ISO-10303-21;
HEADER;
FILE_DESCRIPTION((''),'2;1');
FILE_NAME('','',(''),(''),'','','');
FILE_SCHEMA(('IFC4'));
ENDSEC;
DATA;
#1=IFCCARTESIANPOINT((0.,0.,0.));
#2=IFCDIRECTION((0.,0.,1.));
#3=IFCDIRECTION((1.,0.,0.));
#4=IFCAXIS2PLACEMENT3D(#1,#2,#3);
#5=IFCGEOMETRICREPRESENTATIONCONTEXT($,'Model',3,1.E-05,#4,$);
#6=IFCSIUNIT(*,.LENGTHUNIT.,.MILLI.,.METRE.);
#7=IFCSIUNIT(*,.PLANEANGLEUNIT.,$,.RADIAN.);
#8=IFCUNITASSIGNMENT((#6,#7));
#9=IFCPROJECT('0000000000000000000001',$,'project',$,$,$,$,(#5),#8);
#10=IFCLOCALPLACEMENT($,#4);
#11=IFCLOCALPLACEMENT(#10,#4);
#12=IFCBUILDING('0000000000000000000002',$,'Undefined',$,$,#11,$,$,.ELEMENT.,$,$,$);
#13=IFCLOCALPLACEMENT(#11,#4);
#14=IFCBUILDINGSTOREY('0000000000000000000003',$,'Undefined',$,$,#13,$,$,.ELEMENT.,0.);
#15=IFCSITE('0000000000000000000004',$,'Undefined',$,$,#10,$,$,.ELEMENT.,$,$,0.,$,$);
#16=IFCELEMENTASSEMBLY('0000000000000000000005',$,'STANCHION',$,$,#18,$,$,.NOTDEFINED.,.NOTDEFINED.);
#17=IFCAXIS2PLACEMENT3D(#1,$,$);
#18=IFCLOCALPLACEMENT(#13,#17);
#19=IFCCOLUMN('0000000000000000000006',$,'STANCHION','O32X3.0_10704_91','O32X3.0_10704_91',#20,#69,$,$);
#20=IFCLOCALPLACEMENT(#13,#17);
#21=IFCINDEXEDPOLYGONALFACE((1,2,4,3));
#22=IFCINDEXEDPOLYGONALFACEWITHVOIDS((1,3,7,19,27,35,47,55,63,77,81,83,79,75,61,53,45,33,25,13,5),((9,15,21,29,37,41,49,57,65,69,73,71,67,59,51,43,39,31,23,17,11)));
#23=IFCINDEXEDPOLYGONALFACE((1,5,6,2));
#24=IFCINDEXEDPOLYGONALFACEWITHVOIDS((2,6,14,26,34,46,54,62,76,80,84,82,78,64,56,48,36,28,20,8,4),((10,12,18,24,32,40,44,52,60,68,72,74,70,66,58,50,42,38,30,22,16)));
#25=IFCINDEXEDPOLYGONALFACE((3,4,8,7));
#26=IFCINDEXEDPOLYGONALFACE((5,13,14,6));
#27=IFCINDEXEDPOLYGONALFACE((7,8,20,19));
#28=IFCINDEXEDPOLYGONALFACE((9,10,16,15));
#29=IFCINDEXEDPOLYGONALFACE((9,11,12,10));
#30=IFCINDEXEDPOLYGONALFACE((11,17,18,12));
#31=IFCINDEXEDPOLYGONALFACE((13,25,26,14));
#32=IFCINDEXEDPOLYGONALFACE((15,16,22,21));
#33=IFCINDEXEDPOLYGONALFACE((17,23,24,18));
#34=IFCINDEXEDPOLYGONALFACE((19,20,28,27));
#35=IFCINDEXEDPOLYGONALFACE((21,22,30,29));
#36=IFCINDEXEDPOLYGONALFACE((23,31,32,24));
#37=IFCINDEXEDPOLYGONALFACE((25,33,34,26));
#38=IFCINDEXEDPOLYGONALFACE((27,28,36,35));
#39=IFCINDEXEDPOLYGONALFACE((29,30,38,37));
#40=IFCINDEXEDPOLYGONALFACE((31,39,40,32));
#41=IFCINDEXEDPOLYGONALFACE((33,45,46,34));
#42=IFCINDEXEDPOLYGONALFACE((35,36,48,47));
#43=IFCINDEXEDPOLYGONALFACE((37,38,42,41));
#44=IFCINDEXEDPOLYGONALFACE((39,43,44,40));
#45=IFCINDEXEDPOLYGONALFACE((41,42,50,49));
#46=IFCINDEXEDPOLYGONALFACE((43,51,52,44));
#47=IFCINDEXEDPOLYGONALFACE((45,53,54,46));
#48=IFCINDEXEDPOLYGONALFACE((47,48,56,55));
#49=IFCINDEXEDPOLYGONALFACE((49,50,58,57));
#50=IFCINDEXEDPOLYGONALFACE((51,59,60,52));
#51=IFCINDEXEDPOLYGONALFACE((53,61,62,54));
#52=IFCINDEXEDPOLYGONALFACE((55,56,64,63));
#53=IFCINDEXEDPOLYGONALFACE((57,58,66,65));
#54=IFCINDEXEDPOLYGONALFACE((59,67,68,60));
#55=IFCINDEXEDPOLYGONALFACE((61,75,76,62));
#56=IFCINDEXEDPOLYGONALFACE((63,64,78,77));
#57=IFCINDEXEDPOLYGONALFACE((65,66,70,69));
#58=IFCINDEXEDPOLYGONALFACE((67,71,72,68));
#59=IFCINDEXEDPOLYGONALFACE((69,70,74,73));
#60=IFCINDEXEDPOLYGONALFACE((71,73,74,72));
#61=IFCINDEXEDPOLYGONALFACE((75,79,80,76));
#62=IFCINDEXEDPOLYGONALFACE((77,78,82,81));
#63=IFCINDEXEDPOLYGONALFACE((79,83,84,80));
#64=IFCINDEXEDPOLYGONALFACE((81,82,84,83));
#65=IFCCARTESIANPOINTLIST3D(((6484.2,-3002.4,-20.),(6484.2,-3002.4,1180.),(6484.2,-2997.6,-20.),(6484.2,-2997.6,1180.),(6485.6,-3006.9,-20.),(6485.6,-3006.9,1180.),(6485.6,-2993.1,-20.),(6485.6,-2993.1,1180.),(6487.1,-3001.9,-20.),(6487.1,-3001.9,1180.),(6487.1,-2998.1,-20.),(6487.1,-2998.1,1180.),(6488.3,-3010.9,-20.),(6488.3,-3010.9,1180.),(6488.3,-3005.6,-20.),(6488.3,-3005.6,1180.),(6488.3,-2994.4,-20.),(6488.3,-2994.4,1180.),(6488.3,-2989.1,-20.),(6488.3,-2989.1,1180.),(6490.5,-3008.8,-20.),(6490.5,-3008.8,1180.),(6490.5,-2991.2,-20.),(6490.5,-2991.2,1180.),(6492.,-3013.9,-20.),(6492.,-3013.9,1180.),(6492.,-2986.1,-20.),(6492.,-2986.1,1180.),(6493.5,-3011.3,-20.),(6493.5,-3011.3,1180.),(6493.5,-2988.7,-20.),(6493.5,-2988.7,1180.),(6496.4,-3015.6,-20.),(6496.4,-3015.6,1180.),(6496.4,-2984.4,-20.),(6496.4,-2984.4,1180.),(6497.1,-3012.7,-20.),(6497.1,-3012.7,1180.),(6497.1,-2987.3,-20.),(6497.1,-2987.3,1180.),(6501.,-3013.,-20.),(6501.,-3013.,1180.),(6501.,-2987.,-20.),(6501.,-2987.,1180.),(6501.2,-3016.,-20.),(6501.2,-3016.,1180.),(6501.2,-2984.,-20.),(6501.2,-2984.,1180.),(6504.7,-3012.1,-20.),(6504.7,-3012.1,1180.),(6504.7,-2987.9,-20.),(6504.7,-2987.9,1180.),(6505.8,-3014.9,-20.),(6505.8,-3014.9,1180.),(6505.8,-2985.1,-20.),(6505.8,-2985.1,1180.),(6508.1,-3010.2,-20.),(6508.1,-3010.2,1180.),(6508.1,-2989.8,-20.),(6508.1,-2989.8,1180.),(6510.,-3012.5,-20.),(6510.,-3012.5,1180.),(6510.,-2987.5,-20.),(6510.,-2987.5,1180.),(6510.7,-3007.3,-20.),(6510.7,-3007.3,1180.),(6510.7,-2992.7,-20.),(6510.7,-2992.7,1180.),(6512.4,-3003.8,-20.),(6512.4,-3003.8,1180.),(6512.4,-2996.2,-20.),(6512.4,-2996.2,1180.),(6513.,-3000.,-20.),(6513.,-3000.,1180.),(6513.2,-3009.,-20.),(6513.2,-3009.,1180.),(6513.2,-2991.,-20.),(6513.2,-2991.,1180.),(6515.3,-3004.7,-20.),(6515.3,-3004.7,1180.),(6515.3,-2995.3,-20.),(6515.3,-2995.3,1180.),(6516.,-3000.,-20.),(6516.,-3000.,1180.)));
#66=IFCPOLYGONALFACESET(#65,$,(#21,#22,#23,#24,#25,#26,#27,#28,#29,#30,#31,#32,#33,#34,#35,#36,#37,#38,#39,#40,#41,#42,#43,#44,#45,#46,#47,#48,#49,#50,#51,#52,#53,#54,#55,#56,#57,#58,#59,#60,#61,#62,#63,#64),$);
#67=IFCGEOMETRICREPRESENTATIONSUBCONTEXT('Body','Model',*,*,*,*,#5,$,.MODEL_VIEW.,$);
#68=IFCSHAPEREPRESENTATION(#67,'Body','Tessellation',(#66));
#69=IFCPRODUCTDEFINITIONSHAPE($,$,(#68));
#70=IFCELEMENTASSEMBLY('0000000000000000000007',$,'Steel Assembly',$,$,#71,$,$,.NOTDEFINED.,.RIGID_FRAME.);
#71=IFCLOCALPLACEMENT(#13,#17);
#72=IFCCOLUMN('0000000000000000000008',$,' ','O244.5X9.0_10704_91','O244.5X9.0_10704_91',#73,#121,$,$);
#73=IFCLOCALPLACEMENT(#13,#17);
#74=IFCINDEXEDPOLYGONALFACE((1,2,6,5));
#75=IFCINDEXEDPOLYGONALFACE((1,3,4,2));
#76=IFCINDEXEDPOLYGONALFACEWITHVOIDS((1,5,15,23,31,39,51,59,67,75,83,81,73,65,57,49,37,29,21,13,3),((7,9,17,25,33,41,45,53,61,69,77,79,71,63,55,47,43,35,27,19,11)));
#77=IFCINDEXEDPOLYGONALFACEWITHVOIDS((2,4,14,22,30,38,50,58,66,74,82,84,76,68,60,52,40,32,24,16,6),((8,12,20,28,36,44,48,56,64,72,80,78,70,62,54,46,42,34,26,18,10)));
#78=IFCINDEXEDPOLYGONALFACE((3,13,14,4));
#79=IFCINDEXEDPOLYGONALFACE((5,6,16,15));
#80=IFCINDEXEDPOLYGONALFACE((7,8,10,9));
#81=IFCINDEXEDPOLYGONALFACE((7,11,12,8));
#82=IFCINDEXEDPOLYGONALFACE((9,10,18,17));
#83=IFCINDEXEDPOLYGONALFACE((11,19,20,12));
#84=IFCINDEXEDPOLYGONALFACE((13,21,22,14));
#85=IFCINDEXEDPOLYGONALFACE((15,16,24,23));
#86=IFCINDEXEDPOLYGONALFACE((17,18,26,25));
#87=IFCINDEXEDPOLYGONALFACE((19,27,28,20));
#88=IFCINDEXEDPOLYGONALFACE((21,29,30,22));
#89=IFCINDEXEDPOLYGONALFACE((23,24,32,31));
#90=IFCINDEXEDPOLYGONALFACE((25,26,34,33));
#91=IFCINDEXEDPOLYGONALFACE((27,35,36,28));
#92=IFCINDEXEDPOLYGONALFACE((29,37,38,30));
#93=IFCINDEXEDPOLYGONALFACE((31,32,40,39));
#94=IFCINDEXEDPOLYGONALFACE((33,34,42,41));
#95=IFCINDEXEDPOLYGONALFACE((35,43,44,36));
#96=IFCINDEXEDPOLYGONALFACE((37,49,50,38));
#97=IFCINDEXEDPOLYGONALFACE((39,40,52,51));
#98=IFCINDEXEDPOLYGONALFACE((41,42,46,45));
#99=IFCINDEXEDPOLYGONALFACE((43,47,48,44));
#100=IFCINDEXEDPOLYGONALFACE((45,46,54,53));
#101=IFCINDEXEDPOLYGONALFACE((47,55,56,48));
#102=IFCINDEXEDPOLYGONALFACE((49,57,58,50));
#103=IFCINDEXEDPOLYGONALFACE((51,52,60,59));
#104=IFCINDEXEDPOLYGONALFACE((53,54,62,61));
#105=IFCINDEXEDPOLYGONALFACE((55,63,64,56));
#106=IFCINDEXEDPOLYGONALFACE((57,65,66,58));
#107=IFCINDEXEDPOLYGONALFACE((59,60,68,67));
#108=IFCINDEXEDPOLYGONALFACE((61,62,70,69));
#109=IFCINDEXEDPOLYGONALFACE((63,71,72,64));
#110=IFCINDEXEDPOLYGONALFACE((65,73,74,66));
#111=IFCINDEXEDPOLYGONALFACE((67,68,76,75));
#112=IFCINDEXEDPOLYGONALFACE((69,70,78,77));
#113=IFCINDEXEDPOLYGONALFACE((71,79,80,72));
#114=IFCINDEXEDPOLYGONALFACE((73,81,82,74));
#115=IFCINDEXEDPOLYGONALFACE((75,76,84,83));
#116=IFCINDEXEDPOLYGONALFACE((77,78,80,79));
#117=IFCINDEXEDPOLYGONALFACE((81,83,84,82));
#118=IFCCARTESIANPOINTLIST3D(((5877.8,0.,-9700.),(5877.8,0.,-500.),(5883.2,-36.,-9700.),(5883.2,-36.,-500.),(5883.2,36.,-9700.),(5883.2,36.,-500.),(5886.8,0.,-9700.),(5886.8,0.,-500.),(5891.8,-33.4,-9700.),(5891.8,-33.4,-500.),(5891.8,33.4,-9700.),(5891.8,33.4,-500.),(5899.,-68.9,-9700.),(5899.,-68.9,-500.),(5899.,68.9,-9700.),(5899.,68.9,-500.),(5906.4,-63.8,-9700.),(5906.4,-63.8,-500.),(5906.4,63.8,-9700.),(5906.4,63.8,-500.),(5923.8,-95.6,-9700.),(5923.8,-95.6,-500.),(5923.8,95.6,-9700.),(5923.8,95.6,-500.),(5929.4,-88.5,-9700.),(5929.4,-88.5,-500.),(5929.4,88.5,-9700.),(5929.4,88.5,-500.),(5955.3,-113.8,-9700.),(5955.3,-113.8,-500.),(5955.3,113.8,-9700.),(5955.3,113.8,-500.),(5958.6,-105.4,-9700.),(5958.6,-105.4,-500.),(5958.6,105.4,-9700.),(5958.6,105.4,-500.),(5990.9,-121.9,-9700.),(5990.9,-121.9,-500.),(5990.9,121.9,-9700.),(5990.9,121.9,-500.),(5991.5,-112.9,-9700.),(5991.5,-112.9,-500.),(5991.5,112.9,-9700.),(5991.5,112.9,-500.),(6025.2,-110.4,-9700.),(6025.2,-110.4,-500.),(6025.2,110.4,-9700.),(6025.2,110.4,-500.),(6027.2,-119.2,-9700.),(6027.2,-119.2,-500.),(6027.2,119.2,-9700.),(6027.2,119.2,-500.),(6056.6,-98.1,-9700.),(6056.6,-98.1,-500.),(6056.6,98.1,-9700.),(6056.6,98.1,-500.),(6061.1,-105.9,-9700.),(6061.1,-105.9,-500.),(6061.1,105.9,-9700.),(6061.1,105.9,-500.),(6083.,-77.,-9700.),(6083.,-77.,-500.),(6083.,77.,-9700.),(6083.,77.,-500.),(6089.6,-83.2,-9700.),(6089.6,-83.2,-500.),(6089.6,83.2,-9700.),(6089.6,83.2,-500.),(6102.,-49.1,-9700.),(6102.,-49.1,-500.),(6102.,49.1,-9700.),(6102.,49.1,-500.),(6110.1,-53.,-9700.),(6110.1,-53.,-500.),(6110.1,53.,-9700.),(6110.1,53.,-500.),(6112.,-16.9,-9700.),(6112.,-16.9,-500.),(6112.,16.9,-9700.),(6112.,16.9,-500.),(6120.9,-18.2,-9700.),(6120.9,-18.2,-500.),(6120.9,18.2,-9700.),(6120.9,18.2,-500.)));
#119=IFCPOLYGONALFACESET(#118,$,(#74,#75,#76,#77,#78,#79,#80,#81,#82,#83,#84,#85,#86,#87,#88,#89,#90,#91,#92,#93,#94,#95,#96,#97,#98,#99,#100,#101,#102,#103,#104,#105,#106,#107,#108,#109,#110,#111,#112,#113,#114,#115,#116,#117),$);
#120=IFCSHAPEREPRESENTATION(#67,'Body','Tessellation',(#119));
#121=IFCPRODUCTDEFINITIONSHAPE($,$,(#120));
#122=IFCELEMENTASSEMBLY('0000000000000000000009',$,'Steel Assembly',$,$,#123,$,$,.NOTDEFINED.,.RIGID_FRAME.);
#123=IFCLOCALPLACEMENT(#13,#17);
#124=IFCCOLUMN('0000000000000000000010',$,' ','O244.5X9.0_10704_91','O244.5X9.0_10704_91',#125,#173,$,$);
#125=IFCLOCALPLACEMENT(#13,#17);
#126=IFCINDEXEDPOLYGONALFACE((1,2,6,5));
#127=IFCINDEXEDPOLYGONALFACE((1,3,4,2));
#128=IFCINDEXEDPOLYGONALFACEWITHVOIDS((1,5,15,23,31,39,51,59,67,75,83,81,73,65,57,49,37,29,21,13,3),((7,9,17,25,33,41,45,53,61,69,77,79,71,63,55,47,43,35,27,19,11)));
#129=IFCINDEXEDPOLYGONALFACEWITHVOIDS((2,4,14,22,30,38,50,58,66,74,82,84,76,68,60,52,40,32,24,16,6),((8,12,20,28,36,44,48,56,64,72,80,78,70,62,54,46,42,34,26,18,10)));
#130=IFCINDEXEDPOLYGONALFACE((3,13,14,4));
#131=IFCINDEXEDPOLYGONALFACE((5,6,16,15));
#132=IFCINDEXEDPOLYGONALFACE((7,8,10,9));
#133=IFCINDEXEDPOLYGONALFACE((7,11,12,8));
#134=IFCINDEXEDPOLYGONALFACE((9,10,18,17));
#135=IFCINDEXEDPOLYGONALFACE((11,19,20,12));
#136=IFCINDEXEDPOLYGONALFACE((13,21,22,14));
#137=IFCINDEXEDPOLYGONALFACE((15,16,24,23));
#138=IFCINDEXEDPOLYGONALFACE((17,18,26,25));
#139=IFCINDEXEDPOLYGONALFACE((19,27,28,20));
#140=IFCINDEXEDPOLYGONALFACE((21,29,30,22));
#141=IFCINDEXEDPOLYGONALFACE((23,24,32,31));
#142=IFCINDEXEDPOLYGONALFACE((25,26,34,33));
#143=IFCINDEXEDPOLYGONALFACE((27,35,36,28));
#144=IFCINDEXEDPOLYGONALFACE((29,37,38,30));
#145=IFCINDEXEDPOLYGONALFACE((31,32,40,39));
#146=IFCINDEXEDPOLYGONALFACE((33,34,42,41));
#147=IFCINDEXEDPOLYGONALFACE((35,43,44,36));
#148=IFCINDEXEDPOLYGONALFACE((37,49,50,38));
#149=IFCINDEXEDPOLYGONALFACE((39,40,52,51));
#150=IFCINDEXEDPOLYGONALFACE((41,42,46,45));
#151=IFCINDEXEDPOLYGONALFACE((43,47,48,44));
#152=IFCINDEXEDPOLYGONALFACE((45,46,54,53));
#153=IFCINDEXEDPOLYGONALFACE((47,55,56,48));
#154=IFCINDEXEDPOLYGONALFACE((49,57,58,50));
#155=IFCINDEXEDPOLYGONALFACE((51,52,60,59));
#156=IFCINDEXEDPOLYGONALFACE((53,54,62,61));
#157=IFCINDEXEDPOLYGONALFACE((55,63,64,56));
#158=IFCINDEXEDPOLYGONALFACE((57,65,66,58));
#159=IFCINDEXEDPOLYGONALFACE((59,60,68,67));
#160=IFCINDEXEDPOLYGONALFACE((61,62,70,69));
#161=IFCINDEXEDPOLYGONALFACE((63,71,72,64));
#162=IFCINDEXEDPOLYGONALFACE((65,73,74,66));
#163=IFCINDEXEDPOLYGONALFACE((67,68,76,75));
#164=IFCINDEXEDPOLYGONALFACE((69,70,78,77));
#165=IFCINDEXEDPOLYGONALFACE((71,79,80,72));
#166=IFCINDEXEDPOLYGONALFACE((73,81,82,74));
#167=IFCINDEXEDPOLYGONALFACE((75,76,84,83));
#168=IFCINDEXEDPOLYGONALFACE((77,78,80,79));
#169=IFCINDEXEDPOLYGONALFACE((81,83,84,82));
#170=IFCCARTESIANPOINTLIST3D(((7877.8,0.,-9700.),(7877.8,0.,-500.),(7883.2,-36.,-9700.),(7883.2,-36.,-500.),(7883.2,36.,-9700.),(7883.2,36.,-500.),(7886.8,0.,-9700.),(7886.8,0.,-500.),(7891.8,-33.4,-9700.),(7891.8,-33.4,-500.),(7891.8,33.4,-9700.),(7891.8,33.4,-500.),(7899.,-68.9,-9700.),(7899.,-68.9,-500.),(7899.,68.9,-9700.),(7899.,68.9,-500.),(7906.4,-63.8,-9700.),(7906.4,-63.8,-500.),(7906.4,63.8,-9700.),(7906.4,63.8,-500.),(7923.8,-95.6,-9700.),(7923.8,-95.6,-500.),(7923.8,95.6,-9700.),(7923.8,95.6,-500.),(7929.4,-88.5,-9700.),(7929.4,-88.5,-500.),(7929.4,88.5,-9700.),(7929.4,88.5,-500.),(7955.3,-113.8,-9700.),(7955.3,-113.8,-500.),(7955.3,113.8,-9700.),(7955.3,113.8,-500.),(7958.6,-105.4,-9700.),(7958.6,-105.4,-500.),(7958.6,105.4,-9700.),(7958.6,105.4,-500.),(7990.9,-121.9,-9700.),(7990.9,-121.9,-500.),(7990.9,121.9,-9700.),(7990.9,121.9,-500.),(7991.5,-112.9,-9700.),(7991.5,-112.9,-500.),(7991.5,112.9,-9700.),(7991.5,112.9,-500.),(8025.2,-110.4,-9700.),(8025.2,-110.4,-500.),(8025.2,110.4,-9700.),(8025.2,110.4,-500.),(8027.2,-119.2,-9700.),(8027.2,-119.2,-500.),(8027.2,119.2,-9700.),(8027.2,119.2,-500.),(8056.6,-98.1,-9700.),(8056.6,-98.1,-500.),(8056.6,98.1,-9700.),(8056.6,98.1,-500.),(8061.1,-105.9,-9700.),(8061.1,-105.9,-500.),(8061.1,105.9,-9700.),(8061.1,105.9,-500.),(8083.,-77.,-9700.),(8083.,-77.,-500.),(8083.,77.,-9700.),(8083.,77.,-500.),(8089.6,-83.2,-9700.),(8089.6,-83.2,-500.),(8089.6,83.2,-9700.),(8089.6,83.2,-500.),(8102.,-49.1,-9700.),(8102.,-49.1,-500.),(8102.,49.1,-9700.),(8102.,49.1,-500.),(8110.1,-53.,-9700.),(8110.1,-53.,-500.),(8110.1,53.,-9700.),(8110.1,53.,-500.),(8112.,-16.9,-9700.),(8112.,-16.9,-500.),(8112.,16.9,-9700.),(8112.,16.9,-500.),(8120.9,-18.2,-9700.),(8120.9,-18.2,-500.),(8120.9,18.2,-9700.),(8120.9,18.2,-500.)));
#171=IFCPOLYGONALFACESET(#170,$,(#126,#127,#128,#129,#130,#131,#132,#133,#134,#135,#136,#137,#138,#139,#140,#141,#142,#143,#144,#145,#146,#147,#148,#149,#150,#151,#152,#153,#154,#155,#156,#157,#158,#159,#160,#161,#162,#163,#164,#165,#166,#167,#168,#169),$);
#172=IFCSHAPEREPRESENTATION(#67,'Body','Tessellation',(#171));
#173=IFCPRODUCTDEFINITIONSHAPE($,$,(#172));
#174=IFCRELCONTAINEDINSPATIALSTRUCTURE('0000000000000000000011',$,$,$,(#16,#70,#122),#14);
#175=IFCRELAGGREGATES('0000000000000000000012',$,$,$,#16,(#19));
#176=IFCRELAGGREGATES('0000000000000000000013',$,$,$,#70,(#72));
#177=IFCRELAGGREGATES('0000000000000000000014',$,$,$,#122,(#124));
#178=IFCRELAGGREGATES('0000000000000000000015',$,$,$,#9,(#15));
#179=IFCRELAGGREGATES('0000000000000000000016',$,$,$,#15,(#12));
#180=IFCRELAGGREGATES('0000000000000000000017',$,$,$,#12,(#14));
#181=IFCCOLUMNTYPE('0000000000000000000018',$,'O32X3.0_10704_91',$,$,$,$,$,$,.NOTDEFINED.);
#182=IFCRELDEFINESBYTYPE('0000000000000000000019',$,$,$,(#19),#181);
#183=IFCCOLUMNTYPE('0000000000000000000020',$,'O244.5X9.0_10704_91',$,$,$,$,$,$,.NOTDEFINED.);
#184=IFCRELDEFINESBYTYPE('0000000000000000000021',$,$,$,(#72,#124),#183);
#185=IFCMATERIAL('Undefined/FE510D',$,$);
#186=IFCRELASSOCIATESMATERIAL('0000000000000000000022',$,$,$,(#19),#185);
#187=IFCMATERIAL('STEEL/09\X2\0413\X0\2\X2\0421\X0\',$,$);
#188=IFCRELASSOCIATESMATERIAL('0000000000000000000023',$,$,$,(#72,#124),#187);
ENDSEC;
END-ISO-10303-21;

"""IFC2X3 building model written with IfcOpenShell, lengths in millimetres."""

from ifc_helpers import new_model, si_unit, frame, origin_with_axes, origin_2d_with_axis, place, context, subcontext, project, spatial, hollow_circle, extrude, material, type_object, element, aggregate, save


model = new_model("IFC2X3")

# Units and contexts
model_context = context("Model", 3, precision=1e-05, world=origin_with_axes())
body_context = subcontext(model_context, "Body", "Model", "MODEL_VIEW")
ifc_project = project(units=[si_unit("LENGTHUNIT", "METRE", prefix="MILLI"), si_unit("PLANEANGLEUNIT", "RADIAN")], contexts=[model_context])

# Site, building, storey
site_placement = place(None, origin_with_axes())
site = spatial("IfcSite", under=ifc_project, at=site_placement, Name="Undefined", CompositionType="ELEMENT", RefElevation=0.0)
building_placement = place(site_placement, origin_with_axes())
building = spatial("IfcBuilding", under=site, at=building_placement, Name="Undefined", CompositionType="ELEMENT")
storey_placement = place(building_placement, origin_with_axes())
storey = spatial("IfcBuildingStorey", under=building, at=storey_placement, Name="Undefined", CompositionType="ELEMENT", Elevation=0.0)

# Element assembly, column
assembly_1_placement = place(storey_placement, origin_with_axes())
assembly_1 = element("IfcElementAssembly", 1, at=assembly_1_placement, inside=storey, Name="STANCHION", AssemblyPlace="NOTDEFINED", PredefinedType="NOTDEFINED")
ifc_material_1 = material(Name="Undefined/FE510D")
column_type_1 = type_object("IfcColumnType", Name="O32X3.0_10704_91", PredefinedType="NOTDEFINED")
column_1_placement = place(assembly_1_placement, frame((6500.0, -3000.0, -20.0), z_axis=(0.0, 0.0, 1.0), x_axis=(0.0, -1.0, 0.0)))
column_1 = element("IfcColumn", 2, at=column_1_placement, type_object=column_type_1, material=ifc_material_1, Name="STANCHION", Description="O32X3.0_10704_91", ObjectType="O32X3.0_10704_91", context=body_context, shape_type="SweptSolid", body=[
    extrude(hollow_circle(Radius=16.0, WallThickness=3.0, at=origin_2d_with_axis()), frame((0.0, 0.0, 1200.0), z_axis=(0.0, 0.0, -1.0), x_axis=(0.0, 1.0, 0.0)), (0.0, 0.0, 1.0), 1200.0),
])
aggregate(assembly_1, [column_1])

# Element assemblies, columns
assembly_2_placement = place(storey_placement, origin_with_axes())
assembly_2 = element("IfcElementAssembly", 3, at=assembly_2_placement, inside=storey, Name="Steel Assembly", AssemblyPlace="NOTDEFINED", PredefinedType="RIGID_FRAME")
ifc_material_2 = material(Name="STEEL/09Г2С")
column_type_2 = type_object("IfcColumnType", Name="O244.5X9.0_10704_91", PredefinedType="NOTDEFINED")
column_2_placement = place(assembly_2_placement, frame((6000.0, 0.0, -9700.0), z_axis=(0.0, 0.0, 1.0), x_axis=(0.0, 1.0, 0.0)))
column_2 = element("IfcColumn", 4, at=column_2_placement, type_object=column_type_2, material=ifc_material_2, Name=" ", Description="O244.5X9.0_10704_91", ObjectType="O244.5X9.0_10704_91", context=body_context, shape_type="SweptSolid", body=[
    extrude(hollow_circle(Radius=122.2, WallThickness=9.0, at=origin_2d_with_axis()), frame((0.0, 0.0, 9200.0), z_axis=(0.0, 0.0, -1.0), x_axis=(0.0, 1.0, 0.0)), (0.0, 0.0, 1.0), 9200.0),
])
aggregate(assembly_2, [column_2])
assembly_3_placement = place(storey_placement, origin_with_axes())
assembly_3 = element("IfcElementAssembly", 5, at=assembly_3_placement, inside=storey, Name="Steel Assembly", AssemblyPlace="NOTDEFINED", PredefinedType="RIGID_FRAME")
column_3_placement = place(assembly_3_placement, frame((8000.0, 0.0, -9700.0), z_axis=(0.0, 0.0, 1.0), x_axis=(0.0, 1.0, 0.0)))
column_3 = element("IfcColumn", 6, at=column_3_placement, type_object=column_type_2, material=ifc_material_2, Name=" ", Description="O244.5X9.0_10704_91", ObjectType="O244.5X9.0_10704_91", context=body_context, shape_type="SweptSolid", body=[
    extrude(hollow_circle(Radius=122.2, WallThickness=9.0, at=origin_2d_with_axis()), frame((0.0, 0.0, 9200.0), z_axis=(0.0, 0.0, -1.0), x_axis=(0.0, 1.0, 0.0)), (0.0, 0.0, 1.0), 9200.0),
])
aggregate(assembly_3, [column_3])

save(model, "model.ifc")
